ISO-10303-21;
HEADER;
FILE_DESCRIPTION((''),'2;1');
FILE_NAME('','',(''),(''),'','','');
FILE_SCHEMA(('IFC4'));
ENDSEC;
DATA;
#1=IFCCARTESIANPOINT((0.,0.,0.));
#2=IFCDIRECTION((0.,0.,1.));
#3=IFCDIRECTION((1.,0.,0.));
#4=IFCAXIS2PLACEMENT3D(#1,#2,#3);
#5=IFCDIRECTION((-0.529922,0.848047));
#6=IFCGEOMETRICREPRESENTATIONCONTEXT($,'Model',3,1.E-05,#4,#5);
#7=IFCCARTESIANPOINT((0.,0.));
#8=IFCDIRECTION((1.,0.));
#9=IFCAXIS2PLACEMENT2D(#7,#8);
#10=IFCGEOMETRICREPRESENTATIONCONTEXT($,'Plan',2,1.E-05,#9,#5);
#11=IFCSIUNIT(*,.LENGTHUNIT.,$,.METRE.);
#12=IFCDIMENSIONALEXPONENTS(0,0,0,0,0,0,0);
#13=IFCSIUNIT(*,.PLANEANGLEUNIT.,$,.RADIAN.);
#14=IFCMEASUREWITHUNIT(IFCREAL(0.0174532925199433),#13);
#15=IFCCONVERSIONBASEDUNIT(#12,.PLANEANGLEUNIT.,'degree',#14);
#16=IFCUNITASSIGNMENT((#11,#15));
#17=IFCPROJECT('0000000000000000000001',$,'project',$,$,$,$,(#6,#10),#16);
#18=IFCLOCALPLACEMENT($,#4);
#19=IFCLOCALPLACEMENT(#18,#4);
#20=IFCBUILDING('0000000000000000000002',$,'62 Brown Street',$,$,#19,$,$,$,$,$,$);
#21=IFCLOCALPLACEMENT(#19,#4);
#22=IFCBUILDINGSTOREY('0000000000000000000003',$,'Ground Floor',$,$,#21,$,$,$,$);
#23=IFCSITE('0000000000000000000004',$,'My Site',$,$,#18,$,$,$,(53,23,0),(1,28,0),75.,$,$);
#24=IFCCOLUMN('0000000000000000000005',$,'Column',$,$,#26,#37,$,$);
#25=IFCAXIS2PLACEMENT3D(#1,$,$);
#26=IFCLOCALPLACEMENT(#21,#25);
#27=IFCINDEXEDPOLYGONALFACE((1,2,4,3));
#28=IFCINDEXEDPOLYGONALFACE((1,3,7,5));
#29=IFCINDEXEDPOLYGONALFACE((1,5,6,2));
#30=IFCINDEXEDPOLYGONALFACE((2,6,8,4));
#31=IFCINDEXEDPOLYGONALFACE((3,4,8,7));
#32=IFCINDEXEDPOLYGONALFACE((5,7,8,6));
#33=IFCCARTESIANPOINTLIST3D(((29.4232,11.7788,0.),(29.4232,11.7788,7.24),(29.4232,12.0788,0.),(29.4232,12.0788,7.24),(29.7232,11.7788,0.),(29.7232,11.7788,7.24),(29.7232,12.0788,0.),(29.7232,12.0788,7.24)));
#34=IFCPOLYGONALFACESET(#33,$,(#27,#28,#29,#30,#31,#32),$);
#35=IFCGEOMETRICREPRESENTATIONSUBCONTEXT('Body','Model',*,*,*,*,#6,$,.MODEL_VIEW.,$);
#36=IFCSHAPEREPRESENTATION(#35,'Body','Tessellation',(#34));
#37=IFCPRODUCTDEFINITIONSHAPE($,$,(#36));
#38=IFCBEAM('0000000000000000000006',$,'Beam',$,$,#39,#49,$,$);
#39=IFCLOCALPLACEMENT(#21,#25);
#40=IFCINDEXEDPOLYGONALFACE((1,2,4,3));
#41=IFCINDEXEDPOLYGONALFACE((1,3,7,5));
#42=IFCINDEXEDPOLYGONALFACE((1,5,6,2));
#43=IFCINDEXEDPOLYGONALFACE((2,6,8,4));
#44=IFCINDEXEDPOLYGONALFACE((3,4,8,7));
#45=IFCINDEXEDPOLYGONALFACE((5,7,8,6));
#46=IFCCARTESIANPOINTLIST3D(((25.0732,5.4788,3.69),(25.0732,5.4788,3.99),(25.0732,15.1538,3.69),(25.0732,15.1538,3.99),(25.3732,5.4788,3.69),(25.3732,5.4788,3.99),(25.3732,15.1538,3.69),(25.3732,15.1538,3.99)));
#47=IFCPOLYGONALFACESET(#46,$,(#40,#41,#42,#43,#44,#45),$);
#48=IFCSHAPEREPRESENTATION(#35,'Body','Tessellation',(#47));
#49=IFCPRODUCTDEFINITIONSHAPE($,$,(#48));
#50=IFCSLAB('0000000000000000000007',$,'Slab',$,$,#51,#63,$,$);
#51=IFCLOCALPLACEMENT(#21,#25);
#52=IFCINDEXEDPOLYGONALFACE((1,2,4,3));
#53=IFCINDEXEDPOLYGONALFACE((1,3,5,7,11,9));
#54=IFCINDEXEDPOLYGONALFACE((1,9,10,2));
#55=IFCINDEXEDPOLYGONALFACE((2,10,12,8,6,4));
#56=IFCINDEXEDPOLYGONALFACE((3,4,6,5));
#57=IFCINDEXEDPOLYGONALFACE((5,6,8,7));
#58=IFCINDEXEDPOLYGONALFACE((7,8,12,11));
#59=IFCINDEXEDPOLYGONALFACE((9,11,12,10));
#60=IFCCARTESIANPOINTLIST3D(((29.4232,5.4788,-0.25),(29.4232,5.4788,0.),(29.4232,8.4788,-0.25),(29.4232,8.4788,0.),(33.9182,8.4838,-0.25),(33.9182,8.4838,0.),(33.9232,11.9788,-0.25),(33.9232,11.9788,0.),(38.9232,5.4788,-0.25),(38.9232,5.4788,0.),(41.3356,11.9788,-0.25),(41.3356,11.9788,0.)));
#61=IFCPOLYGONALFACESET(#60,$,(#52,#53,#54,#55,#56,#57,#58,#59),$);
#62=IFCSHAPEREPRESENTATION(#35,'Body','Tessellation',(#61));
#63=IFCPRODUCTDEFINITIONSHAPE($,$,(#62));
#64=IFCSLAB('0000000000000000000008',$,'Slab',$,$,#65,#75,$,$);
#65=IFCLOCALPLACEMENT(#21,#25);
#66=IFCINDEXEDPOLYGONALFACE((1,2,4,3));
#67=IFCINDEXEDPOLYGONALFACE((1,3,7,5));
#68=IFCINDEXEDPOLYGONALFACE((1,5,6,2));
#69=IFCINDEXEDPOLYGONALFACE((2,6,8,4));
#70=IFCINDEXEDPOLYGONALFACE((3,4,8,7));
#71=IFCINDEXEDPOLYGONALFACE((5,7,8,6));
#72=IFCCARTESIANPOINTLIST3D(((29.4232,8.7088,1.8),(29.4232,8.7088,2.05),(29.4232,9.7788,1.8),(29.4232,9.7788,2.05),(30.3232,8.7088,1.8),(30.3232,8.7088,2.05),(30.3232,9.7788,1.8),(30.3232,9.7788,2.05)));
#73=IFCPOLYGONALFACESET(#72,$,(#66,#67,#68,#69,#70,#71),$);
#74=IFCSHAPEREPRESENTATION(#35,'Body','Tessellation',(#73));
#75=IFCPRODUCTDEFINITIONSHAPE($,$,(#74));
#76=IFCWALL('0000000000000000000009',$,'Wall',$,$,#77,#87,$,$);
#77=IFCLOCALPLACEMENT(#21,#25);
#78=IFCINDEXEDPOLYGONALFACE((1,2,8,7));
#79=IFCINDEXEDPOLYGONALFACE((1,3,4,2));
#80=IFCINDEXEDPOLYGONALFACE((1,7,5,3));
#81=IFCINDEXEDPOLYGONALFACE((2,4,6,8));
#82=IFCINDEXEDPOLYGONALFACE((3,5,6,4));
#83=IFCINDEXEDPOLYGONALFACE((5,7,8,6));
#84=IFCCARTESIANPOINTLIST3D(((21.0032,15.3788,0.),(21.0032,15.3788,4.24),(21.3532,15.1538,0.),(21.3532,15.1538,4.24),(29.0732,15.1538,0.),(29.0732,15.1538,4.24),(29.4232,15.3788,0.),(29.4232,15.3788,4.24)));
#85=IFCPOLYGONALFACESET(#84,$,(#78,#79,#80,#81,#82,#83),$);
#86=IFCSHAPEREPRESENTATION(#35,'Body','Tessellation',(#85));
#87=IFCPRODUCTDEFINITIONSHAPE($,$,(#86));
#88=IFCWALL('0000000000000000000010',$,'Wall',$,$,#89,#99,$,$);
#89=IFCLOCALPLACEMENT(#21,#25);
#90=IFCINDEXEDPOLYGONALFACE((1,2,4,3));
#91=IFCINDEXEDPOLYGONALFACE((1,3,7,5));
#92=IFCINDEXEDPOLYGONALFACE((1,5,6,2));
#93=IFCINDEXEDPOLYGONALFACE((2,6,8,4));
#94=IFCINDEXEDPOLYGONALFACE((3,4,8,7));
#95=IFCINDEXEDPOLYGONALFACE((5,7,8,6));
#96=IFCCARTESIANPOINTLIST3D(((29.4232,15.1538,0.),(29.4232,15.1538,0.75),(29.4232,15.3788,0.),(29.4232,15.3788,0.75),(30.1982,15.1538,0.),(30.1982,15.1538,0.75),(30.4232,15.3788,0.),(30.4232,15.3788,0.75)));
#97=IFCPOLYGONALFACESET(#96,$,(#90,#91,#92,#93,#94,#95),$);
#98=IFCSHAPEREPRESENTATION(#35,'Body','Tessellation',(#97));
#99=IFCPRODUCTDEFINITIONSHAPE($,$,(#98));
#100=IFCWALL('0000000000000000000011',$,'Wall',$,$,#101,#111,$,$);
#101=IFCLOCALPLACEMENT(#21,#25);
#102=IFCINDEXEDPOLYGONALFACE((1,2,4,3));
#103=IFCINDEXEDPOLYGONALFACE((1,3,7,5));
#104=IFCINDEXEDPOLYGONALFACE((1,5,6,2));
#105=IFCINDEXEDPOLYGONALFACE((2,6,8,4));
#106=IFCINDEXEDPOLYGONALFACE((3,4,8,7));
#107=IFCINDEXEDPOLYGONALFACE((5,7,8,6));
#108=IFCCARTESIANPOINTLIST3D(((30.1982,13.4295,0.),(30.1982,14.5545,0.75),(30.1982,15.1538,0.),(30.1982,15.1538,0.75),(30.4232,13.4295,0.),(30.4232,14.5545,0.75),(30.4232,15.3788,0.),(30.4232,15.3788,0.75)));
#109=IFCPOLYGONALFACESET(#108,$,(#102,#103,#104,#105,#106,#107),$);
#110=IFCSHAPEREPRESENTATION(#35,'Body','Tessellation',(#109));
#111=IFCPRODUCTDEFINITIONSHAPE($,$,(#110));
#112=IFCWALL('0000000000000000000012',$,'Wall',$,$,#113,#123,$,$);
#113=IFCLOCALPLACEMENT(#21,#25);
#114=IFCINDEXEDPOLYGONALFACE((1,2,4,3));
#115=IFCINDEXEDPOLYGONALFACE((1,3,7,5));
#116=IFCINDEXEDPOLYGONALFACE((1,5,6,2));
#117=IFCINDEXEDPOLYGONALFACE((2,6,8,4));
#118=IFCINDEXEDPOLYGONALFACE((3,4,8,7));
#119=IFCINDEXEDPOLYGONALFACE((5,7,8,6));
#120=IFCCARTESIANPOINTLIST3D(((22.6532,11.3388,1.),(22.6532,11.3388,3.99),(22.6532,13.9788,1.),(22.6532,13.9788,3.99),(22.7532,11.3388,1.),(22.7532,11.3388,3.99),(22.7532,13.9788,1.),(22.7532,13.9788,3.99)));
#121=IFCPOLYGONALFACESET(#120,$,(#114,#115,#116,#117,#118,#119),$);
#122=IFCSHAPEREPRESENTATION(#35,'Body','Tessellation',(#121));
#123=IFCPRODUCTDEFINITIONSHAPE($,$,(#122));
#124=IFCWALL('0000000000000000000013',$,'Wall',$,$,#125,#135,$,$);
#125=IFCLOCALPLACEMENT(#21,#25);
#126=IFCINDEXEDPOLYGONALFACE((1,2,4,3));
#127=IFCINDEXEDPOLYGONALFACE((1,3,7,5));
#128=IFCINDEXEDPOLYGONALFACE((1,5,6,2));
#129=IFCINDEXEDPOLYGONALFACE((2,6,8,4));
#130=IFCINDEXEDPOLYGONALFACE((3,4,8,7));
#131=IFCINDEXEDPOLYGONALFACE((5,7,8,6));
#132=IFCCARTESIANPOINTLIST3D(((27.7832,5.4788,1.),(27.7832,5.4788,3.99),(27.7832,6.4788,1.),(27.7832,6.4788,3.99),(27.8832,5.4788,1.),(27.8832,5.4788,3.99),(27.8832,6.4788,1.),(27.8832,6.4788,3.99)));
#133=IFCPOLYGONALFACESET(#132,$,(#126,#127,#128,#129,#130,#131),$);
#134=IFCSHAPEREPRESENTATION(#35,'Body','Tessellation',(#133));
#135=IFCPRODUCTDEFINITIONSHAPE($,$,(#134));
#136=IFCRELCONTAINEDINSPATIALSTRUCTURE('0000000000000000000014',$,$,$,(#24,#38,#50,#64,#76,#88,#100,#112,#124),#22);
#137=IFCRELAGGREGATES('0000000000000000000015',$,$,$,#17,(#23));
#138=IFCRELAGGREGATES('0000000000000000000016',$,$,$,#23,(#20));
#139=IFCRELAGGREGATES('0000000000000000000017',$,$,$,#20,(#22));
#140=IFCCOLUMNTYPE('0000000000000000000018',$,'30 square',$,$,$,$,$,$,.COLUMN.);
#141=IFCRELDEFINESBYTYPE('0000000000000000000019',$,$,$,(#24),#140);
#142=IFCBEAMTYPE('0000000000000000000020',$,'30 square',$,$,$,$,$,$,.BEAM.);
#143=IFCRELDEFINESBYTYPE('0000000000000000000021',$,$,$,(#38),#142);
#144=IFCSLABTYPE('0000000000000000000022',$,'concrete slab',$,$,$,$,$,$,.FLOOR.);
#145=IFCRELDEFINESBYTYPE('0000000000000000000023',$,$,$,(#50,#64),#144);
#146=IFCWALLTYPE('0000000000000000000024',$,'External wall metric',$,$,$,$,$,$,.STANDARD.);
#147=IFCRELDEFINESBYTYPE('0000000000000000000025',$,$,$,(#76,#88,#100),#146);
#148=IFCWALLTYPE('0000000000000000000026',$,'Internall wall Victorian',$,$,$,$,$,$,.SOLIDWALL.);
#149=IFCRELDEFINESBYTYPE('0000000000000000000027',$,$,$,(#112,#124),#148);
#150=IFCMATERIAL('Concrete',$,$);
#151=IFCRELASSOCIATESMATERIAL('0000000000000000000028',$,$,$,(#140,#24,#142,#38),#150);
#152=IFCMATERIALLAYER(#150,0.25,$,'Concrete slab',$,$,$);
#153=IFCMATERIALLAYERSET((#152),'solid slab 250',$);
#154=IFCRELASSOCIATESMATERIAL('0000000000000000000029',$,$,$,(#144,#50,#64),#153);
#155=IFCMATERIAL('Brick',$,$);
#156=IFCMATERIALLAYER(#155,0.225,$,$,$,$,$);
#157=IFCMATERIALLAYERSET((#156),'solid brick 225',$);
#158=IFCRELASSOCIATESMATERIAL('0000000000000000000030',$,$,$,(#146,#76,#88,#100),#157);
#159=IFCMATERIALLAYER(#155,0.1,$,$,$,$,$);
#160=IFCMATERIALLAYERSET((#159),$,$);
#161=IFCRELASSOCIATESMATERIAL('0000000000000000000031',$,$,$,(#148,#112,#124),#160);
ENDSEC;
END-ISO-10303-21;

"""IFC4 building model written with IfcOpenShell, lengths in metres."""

from ifc_helpers import new_model, entity, si_unit, converted_unit, direction, frame, origin_with_axes, origin_2d_with_axis, place, context, subcontext, project, spatial, line, indexed_curve, rectangle, outline, extrude, clip, halfspace, material, layer, layer_set, layer_usage, material_profile, profile_set, profile_usage, type_object, element, save


model = new_model("IFC4")

# Units and contexts
model_context = context("Model", 3, precision=1e-05, world=origin_with_axes(), true_north=direction((-0.529922, 0.848047)))
plan_context = context("Plan", 2, precision=1e-05, world=origin_2d_with_axis(), true_north=direction((-0.529922, 0.848047)))
body_context = subcontext(model_context, "Body", "Model", "MODEL_VIEW")
ifc_project = project(units=[si_unit("LENGTHUNIT", "METRE"), converted_unit("PLANEANGLEUNIT", "degree", entity("IfcReal", 0.0174532925199433), si_unit("PLANEANGLEUNIT", "RADIAN"), dimensions=[0, 0, 0, 0, 0, 0, 0])], contexts=[model_context, plan_context])

# Site, building, storey
site_placement = place(None, origin_with_axes())
site = spatial("IfcSite", under=ifc_project, at=site_placement, Name="My Site", RefLatitude=(53, 23, 0), RefLongitude=(1, 28, 0), RefElevation=75.0)
building_placement = place(site_placement, origin_with_axes())
building = spatial("IfcBuilding", under=site, at=building_placement, Name="62 Brown Street")
storey_placement = place(building_placement, origin_with_axes())
storey = spatial("IfcBuildingStorey", under=building, at=storey_placement, Name="Ground Floor")

# Column
ifc_material_1 = material(Name="Concrete")
ifc_material_profile_1 = material_profile(ifc_material_1, rectangle(XDim=0.3, YDim=0.3))
ifc_profile_set_1 = profile_set([ifc_material_profile_1])
ifc_profile_usage_1 = profile_usage(ifc_profile_set_1, cardinal=5)
column_type = type_object("IfcColumnType", Name="30 square", PredefinedType="COLUMN", material=ifc_profile_set_1)
column_1_placement = place(storey_placement, frame((29.5732, 11.9288, 0.0), z_axis=(0.0, 0.0, 1.0), x_axis=(1.0, 0.0, 0.0)))
element("IfcColumn", 1, at=column_1_placement, inside=storey, type_object=column_type, material=ifc_profile_usage_1, Name="Column", context=body_context, shape_type="SweptSolid", body=[
    extrude(rectangle(XDim=0.3, YDim=0.3), origin_with_axes(), (0.0, 0.0, 1.0), 7.24),
])

# Beam
ifc_material_profile_2 = material_profile(ifc_material_1, rectangle(XDim=0.3, YDim=0.3))
ifc_profile_set_2 = profile_set([ifc_material_profile_2])
ifc_profile_usage_2 = profile_usage(ifc_profile_set_2, cardinal=5)
beam_type = type_object("IfcBeamType", Name="30 square", PredefinedType="BEAM", material=ifc_profile_set_2)
beam_placement = place(storey_placement, frame((25.2232, 5.4788, 3.84), z_axis=(0.0, 1.0, 0.0), x_axis=(-1.0, 0.0, 0.0)))
element("IfcBeam", 2, at=beam_placement, inside=storey, type_object=beam_type, material=ifc_profile_usage_2, Name="Beam", context=body_context, shape_type="SweptSolid", body=[
    extrude(rectangle(XDim=0.3, YDim=0.3), origin_with_axes(), (0.0, 0.0, 1.0), 9.675),
])

# Slabs
ifc_layer_1 = layer(ifc_material_1, 0.25, Name="Concrete slab")
ifc_layer_set_1 = layer_set([ifc_layer_1], Name="solid slab 250")
ifc_layer_usage_1 = layer_usage(ifc_layer_set_1, "AXIS3", "POSITIVE", 0.0)
slab_type = type_object("IfcSlabType", Name="concrete slab", PredefinedType="FLOOR", material=ifc_layer_set_1)
slab_1_placement = place(storey_placement, frame((29.4232, 5.4788, -0.25), z_axis=(0.0, 0.0, 1.0), x_axis=(1.0, 0.0, 0.0)))
element("IfcSlab", 3, at=slab_1_placement, inside=storey, type_object=slab_type, material=ifc_layer_usage_1, Name="Slab", context=body_context, shape_type="SweptSolid", body=[
    extrude(outline(indexed_curve([(0.0, 0.0), (9.5, 0.0), (11.9124, 6.5), (0.0, 3.0), (4.5, 6.5), (4.495, 3.005)], segments=[line(1, 2), line(2, 3), line(3, 5), line(5, 6), line(6, 4), line(4, 1)], self_intersect=False)), None, (0.0, 0.0, 1.0), 0.25),
])
ifc_layer_usage_2 = layer_usage(ifc_layer_set_1, "AXIS3", "POSITIVE", 0.0)
slab_2_placement = place(storey_placement, frame((29.4232, 8.7088, 1.8), z_axis=(0.0, 0.0, 1.0), x_axis=(1.0, 0.0, 0.0)))
element("IfcSlab", 4, at=slab_2_placement, inside=storey, type_object=slab_type, material=ifc_layer_usage_2, Name="Slab", context=body_context, shape_type="SweptSolid", body=[
    extrude(outline(indexed_curve([(0.9, 1.07), (0.9, 0.0), (0.0, 0.0), (0.0, 1.07)], segments=[line(3, 2), line(2, 1), line(1, 4), line(4, 3)], self_intersect=False)), None, (0.0, 0.0, 1.0), 0.25),
])

# Walls
ifc_material_2 = material(Name="Brick")
ifc_layer_2 = layer(ifc_material_2, 0.225)
ifc_layer_set_2 = layer_set([ifc_layer_2], Name="solid brick 225")
wall_type_1 = type_object("IfcWallType", Name="External wall metric", PredefinedType="STANDARD", material=ifc_layer_set_2)
ifc_layer_usage_3 = layer_usage(ifc_layer_set_2, "AXIS2", "POSITIVE", 0.0)
wall_1_placement = place(storey_placement, frame((29.4232, 15.3788, 0.0), z_axis=(0.0, 0.0, 1.0), x_axis=(-1.0, 0.0, 0.0)))
element("IfcWall", 5, at=wall_1_placement, inside=storey, type_object=wall_type_1, material=ifc_layer_usage_3, Name="Wall", context=body_context, shape_type="Clipping", body=[
    clip(clip(extrude(outline(indexed_curve([(0.0, 0.0), (0.0, 0.225), (8.42, 0.225), (8.42, 0.0), (0.0, 0.0)], self_intersect=False)), origin_with_axes(), (0.0, 0.0, 1.0), 4.24), halfspace(frame((8.42, 0.0, 0.0), z_axis=(0.540756, 0.841179, 0.0), x_axis=(-0.841179, 0.540756, 0.0)), False)), halfspace(frame((0.0, 0.0, 0.0), z_axis=(-0.540758, 0.841178, 0.0), x_axis=(0.841178, 0.540758, 0.0)), False)),
])
ifc_layer_usage_4 = layer_usage(ifc_layer_set_2, "AXIS2", "POSITIVE", 0.0)
wall_2_placement = place(storey_placement, frame((30.4232, 15.3788, 0.0), z_axis=(0.0, 0.0, 1.0), x_axis=(-1.0, 0.0, 0.0)))
element("IfcWall", 6, at=wall_2_placement, inside=storey, type_object=wall_type_1, material=ifc_layer_usage_4, Name="Wall", context=body_context, shape_type="Clipping", body=[
    clip(extrude(outline(indexed_curve([(0.0, 0.0), (0.0, 0.225), (1.0, 0.225), (1.0, 0.0), (0.0, 0.0)], self_intersect=False)), origin_with_axes(), (0.0, 0.0, 1.0), 0.75), halfspace(frame((0.0, 0.0, 0.0), z_axis=(-0.707107, 0.707107, 0.0), x_axis=(0.707107, 0.707107, 0.0)), False)),
])
ifc_layer_usage_5 = layer_usage(ifc_layer_set_2, "AXIS2", "POSITIVE", 0.0)
wall_3_placement = place(storey_placement, frame((30.4232, 13.4295, 0.0), z_axis=(0.0, 0.0, 1.0), x_axis=(0.0, 1.0, 0.0)))
element("IfcWall", 7, at=wall_3_placement, inside=storey, type_object=wall_type_1, material=ifc_layer_usage_5, Name="Wall", context=body_context, shape_type="Clipping", body=[
    clip(clip(extrude(outline(indexed_curve([(0.0, 0.0), (0.0, 0.225), (1.9493, 0.225), (1.9493, 0.0), (0.0, 0.0)], self_intersect=False)), origin_with_axes(), (0.0, 0.0, 1.0), 0.75), halfspace(frame((0.416, 0.5, 0.2774), z_axis=(-0.5547, 0.0, 0.83205), x_axis=(0.0, -1.0, 0.0)), False)), halfspace(frame((1.9493, 0.0, 0.0), z_axis=(0.707107, 0.707107, 0.0), x_axis=(0.707107, -0.707107, 0.0)), False)),
])
ifc_layer_3 = layer(ifc_material_2, 0.1)
ifc_layer_set_3 = layer_set([ifc_layer_3])
ifc_layer_usage_6 = layer_usage(ifc_layer_set_3, "AXIS2", "POSITIVE", 0.0)
wall_type_2 = type_object("IfcWallType", Name="Internall wall Victorian", PredefinedType="SOLIDWALL", material=ifc_layer_set_3)
wall_4_placement = place(storey_placement, frame((22.7532, 11.3388, 1.0), z_axis=(0.0, 0.0, 1.0), x_axis=(0.0, 1.0, 0.0)))
element("IfcWall", 8, at=wall_4_placement, inside=storey, type_object=wall_type_2, material=ifc_layer_usage_6, Name="Wall", context=body_context, shape_type="SweptSolid", body=[
    extrude(outline(indexed_curve([(0.0, 0.0), (0.0, 0.1), (2.64, 0.1), (2.64, 0.0), (0.0, 0.0)], self_intersect=False)), origin_with_axes(), (0.0, 0.0, 1.0), 2.99),
])
ifc_layer_usage_7 = layer_usage(ifc_layer_set_3, "AXIS2", "POSITIVE", 0.0)
wall_5_placement = place(storey_placement, frame((27.8832, 5.4788, 1.0), z_axis=(0.0, 0.0, 1.0), x_axis=(0.0, 1.0, 0.0)))
element("IfcWall", 9, at=wall_5_placement, inside=storey, type_object=wall_type_2, material=ifc_layer_usage_7, Name="Wall", context=body_context, shape_type="SweptSolid", body=[
    extrude(outline(indexed_curve([(0.0, 0.0), (0.0, 0.1), (1.0, 0.1), (1.0, 0.0), (0.0, 0.0)], self_intersect=False)), origin_with_axes(), (0.0, 0.0, 1.0), 2.99),
])

save(model, "model.ifc")
